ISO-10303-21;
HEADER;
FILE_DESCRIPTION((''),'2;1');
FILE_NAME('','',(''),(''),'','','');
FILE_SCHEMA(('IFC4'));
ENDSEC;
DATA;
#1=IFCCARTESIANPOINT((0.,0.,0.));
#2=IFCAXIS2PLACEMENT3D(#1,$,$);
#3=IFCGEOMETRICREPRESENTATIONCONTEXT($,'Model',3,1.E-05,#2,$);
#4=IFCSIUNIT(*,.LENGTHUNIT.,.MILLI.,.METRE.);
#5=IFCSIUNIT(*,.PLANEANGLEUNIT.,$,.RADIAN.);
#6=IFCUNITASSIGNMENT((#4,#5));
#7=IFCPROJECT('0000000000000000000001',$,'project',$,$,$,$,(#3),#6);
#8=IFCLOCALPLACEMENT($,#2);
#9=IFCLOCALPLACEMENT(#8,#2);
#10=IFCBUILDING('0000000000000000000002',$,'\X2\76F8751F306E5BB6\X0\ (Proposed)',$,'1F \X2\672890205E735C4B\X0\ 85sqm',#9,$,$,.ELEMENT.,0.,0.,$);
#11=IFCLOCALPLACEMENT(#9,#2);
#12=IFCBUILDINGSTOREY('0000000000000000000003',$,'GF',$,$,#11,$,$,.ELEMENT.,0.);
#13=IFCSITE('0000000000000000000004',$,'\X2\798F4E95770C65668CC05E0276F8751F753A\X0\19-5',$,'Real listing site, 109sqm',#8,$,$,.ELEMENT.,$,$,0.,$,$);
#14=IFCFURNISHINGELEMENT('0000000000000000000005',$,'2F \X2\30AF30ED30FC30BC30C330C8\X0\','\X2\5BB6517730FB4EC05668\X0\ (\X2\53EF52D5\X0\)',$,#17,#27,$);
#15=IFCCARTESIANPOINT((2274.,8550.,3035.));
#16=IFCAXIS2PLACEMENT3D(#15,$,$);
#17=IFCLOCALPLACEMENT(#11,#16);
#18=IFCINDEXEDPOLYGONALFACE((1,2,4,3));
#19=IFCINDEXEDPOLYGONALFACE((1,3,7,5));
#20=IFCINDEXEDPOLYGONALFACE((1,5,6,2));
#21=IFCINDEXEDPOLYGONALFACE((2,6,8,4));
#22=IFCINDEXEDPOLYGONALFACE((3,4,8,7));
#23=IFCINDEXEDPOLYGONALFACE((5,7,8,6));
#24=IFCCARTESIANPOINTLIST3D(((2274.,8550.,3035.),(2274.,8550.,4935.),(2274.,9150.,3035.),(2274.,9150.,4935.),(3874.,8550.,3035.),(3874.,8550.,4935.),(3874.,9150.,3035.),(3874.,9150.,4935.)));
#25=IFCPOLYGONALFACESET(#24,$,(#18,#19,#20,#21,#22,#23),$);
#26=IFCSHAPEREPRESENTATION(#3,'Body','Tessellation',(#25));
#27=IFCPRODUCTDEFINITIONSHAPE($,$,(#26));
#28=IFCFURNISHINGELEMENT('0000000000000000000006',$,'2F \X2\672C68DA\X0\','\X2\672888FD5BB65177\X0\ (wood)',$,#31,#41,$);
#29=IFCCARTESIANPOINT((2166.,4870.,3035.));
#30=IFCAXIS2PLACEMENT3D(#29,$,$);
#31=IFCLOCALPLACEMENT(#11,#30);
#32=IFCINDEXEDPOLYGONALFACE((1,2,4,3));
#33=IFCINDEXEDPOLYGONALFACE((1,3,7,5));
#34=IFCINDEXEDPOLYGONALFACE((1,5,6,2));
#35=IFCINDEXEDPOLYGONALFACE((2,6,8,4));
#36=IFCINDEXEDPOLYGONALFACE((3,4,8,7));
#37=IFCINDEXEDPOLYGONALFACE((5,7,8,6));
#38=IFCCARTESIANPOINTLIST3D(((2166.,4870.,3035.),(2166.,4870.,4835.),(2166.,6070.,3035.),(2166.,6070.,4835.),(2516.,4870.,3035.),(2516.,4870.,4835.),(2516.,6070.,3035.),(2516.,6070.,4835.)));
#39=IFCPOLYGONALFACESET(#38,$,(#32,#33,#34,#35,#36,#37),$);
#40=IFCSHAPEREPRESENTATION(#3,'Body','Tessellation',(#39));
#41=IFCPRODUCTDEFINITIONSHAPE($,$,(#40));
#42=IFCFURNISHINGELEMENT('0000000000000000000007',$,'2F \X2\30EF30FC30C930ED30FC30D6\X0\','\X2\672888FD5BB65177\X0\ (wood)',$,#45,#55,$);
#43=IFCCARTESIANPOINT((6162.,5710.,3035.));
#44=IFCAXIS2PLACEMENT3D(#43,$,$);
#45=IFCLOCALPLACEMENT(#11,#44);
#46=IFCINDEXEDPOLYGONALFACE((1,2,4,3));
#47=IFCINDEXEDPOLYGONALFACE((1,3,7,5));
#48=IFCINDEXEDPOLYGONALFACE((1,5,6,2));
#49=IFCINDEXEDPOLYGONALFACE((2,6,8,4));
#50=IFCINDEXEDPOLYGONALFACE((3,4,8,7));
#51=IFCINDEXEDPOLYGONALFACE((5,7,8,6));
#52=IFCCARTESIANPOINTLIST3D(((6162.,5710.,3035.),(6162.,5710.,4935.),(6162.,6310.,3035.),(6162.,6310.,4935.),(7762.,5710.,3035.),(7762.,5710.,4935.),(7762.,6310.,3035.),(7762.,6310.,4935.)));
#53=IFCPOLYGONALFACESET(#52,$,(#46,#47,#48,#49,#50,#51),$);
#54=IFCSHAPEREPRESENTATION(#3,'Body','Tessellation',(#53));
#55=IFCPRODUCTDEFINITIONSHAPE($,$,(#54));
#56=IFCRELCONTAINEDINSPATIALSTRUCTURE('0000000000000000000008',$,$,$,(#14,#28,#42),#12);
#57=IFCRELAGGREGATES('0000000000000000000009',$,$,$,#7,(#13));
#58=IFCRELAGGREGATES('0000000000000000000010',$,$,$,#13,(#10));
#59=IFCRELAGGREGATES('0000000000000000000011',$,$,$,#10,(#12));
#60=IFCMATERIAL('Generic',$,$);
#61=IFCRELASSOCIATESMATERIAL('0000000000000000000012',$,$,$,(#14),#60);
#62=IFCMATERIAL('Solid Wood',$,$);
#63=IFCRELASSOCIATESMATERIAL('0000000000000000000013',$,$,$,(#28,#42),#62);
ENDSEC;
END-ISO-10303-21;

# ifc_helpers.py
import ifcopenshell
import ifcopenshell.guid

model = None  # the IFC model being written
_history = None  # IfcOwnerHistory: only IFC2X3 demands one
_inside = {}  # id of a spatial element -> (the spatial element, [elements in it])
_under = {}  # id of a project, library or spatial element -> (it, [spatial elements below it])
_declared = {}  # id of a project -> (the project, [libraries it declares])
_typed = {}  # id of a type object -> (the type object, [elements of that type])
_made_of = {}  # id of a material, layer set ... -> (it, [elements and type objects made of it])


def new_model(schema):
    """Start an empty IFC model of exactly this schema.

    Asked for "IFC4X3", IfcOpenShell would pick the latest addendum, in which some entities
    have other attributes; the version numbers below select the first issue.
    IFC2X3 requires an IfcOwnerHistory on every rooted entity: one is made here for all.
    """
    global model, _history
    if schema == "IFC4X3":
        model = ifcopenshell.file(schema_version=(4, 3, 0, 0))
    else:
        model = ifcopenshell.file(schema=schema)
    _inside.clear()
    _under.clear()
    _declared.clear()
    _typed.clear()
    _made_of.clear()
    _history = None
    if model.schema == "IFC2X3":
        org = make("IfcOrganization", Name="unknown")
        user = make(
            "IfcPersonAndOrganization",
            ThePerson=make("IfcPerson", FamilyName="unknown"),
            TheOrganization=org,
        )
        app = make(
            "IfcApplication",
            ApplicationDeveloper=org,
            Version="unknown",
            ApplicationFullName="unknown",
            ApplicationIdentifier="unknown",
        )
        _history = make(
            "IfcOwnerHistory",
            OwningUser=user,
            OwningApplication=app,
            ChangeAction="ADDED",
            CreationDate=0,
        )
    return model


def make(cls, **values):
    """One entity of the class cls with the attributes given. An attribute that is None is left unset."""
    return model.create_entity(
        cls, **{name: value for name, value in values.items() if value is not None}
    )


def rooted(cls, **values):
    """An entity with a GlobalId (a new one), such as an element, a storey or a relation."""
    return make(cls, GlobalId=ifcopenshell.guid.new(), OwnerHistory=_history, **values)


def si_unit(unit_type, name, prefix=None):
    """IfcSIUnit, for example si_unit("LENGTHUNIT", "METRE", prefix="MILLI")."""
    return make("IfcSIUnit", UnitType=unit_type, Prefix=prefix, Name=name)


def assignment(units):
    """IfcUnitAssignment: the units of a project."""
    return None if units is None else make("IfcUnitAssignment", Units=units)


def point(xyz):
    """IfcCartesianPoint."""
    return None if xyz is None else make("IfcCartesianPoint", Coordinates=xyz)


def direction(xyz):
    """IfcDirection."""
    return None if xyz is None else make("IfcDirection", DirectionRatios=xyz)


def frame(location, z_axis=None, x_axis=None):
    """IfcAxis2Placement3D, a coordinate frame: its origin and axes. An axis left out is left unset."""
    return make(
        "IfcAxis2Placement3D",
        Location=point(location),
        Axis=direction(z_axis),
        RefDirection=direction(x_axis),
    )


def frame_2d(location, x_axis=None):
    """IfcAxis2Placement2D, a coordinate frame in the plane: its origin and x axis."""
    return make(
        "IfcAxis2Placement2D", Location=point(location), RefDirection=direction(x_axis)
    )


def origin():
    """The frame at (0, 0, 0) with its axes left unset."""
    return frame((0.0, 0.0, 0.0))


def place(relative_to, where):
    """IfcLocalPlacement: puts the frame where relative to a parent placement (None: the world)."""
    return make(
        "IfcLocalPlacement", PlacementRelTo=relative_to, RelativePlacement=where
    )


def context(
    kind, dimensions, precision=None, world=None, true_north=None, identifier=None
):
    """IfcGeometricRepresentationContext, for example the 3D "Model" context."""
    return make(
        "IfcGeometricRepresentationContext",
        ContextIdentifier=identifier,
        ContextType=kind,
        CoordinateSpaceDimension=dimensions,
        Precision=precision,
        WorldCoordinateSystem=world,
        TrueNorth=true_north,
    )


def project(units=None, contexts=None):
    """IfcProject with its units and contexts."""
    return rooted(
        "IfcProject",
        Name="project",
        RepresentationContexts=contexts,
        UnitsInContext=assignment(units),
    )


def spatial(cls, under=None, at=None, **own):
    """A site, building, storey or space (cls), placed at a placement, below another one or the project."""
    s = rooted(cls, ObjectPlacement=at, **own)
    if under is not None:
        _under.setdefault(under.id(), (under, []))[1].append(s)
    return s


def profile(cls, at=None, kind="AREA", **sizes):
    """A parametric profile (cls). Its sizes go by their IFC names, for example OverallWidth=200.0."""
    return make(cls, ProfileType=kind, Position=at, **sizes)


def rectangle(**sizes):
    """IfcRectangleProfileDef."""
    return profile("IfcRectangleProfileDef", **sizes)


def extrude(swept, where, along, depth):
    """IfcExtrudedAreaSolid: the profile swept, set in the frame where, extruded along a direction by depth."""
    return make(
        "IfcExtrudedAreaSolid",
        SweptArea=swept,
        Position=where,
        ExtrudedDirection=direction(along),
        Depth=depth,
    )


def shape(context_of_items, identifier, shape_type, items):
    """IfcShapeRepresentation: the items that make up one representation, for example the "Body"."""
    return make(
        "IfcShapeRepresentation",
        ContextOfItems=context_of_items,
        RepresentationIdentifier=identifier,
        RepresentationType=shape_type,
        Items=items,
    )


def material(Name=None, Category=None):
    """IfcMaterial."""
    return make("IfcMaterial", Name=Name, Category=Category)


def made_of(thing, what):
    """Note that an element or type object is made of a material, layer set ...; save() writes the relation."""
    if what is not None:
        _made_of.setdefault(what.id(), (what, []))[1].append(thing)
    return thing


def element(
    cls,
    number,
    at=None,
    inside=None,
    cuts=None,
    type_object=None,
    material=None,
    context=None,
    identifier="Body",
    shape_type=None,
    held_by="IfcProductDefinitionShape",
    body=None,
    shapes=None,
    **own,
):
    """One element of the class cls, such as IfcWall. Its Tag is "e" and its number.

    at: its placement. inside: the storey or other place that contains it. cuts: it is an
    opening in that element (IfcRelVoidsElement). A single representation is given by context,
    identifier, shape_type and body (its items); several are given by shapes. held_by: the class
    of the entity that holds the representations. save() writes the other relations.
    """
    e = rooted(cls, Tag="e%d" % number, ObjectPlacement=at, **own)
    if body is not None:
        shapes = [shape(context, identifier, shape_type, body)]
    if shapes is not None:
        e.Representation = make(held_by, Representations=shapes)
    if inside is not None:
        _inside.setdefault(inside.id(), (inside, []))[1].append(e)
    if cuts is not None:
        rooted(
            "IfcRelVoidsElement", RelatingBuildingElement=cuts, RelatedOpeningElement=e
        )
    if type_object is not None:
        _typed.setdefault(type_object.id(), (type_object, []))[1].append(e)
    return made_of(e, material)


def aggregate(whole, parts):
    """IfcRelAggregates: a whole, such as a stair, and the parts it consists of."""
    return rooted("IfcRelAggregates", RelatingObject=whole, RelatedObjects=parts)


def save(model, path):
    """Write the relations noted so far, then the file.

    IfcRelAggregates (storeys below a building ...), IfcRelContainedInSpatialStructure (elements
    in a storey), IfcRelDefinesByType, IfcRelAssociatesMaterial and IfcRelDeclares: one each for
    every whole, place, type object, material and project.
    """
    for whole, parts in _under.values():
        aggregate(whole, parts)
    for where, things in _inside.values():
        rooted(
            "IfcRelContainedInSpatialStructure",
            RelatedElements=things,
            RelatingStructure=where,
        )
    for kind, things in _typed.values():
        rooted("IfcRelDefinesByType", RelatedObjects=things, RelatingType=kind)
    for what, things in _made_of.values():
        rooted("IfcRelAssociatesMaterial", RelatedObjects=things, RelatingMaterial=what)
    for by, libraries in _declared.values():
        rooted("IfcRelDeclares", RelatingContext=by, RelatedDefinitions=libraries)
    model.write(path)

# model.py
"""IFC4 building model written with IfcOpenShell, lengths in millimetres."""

from ifc_helpers import new_model, si_unit, frame, frame_2d, origin, place, context, project, spatial, rectangle, extrude, material, element, save


model = new_model("IFC4")

# Units and contexts
model_context = context("Model", 3, precision=1e-05, world=origin())
ifc_project = project(units=[si_unit("LENGTHUNIT", "METRE", prefix="MILLI"), si_unit("PLANEANGLEUNIT", "RADIAN")], contexts=[model_context])

# Site, building, storey
site_placement = place(None, origin())
site = spatial("IfcSite", under=ifc_project, at=site_placement, Name="福井県敦賀市相生町19-5", ObjectType="Real listing site, 109sqm", CompositionType="ELEMENT", RefElevation=0.0)
building_placement = place(site_placement, origin())
building = spatial("IfcBuilding", under=site, at=building_placement, Name="相生の家 (Proposed)", ObjectType="1F 木造平屋 85sqm", CompositionType="ELEMENT", ElevationOfRefHeight=0.0, ElevationOfTerrain=0.0)
storey_placement = place(building_placement, origin())
storey = spatial("IfcBuildingStorey", under=building, at=storey_placement, Name="GF", CompositionType="ELEMENT", Elevation=0.0)

# Shared definitions
ifc_material_1 = material(Name="Solid Wood")

# Shared definitions
ifc_material_2 = material(Name="Generic")

# Furnishing elements
furnishing_1_placement = place(storey_placement, frame((2274.0, 8550.0, 3035.0)))
element("IfcFurnishingElement", 1, at=furnishing_1_placement, inside=storey, material=ifc_material_2, Name="2F クローゼット", Description="家具・什器 (可動)", context=model_context, shape_type="SweptSolid", body=[
    extrude(rectangle(XDim=1600.0, YDim=600.0, at=frame_2d((800.0, 300.0))), frame((2274.0, 8550.0, 3035.0)), (0.0, 0.0, 1.0), 1900.0),
])
furnishing_2_placement = place(storey_placement, frame((2166.0, 4870.0, 3035.0)))
element("IfcFurnishingElement", 2, at=furnishing_2_placement, inside=storey, material=ifc_material_1, Name="2F 本棚", Description="木製家具 (wood)", context=model_context, shape_type="SweptSolid", body=[
    extrude(rectangle(XDim=350.0, YDim=1200.0, at=frame_2d((175.0, 600.0))), frame((2166.0, 4870.0, 3035.0)), (0.0, 0.0, 1.0), 1800.0),
])
furnishing_3_placement = place(storey_placement, frame((6162.0, 5710.0, 3035.0)))
element("IfcFurnishingElement", 3, at=furnishing_3_placement, inside=storey, material=ifc_material_1, Name="2F ワードローブ", Description="木製家具 (wood)", context=model_context, shape_type="SweptSolid", body=[
    extrude(rectangle(XDim=1600.0, YDim=600.0, at=frame_2d((800.0, 300.0))), frame((6162.0, 5710.0, 3035.0)), (0.0, 0.0, 1.0), 1900.0),
])

save(model, "model.ifc")
